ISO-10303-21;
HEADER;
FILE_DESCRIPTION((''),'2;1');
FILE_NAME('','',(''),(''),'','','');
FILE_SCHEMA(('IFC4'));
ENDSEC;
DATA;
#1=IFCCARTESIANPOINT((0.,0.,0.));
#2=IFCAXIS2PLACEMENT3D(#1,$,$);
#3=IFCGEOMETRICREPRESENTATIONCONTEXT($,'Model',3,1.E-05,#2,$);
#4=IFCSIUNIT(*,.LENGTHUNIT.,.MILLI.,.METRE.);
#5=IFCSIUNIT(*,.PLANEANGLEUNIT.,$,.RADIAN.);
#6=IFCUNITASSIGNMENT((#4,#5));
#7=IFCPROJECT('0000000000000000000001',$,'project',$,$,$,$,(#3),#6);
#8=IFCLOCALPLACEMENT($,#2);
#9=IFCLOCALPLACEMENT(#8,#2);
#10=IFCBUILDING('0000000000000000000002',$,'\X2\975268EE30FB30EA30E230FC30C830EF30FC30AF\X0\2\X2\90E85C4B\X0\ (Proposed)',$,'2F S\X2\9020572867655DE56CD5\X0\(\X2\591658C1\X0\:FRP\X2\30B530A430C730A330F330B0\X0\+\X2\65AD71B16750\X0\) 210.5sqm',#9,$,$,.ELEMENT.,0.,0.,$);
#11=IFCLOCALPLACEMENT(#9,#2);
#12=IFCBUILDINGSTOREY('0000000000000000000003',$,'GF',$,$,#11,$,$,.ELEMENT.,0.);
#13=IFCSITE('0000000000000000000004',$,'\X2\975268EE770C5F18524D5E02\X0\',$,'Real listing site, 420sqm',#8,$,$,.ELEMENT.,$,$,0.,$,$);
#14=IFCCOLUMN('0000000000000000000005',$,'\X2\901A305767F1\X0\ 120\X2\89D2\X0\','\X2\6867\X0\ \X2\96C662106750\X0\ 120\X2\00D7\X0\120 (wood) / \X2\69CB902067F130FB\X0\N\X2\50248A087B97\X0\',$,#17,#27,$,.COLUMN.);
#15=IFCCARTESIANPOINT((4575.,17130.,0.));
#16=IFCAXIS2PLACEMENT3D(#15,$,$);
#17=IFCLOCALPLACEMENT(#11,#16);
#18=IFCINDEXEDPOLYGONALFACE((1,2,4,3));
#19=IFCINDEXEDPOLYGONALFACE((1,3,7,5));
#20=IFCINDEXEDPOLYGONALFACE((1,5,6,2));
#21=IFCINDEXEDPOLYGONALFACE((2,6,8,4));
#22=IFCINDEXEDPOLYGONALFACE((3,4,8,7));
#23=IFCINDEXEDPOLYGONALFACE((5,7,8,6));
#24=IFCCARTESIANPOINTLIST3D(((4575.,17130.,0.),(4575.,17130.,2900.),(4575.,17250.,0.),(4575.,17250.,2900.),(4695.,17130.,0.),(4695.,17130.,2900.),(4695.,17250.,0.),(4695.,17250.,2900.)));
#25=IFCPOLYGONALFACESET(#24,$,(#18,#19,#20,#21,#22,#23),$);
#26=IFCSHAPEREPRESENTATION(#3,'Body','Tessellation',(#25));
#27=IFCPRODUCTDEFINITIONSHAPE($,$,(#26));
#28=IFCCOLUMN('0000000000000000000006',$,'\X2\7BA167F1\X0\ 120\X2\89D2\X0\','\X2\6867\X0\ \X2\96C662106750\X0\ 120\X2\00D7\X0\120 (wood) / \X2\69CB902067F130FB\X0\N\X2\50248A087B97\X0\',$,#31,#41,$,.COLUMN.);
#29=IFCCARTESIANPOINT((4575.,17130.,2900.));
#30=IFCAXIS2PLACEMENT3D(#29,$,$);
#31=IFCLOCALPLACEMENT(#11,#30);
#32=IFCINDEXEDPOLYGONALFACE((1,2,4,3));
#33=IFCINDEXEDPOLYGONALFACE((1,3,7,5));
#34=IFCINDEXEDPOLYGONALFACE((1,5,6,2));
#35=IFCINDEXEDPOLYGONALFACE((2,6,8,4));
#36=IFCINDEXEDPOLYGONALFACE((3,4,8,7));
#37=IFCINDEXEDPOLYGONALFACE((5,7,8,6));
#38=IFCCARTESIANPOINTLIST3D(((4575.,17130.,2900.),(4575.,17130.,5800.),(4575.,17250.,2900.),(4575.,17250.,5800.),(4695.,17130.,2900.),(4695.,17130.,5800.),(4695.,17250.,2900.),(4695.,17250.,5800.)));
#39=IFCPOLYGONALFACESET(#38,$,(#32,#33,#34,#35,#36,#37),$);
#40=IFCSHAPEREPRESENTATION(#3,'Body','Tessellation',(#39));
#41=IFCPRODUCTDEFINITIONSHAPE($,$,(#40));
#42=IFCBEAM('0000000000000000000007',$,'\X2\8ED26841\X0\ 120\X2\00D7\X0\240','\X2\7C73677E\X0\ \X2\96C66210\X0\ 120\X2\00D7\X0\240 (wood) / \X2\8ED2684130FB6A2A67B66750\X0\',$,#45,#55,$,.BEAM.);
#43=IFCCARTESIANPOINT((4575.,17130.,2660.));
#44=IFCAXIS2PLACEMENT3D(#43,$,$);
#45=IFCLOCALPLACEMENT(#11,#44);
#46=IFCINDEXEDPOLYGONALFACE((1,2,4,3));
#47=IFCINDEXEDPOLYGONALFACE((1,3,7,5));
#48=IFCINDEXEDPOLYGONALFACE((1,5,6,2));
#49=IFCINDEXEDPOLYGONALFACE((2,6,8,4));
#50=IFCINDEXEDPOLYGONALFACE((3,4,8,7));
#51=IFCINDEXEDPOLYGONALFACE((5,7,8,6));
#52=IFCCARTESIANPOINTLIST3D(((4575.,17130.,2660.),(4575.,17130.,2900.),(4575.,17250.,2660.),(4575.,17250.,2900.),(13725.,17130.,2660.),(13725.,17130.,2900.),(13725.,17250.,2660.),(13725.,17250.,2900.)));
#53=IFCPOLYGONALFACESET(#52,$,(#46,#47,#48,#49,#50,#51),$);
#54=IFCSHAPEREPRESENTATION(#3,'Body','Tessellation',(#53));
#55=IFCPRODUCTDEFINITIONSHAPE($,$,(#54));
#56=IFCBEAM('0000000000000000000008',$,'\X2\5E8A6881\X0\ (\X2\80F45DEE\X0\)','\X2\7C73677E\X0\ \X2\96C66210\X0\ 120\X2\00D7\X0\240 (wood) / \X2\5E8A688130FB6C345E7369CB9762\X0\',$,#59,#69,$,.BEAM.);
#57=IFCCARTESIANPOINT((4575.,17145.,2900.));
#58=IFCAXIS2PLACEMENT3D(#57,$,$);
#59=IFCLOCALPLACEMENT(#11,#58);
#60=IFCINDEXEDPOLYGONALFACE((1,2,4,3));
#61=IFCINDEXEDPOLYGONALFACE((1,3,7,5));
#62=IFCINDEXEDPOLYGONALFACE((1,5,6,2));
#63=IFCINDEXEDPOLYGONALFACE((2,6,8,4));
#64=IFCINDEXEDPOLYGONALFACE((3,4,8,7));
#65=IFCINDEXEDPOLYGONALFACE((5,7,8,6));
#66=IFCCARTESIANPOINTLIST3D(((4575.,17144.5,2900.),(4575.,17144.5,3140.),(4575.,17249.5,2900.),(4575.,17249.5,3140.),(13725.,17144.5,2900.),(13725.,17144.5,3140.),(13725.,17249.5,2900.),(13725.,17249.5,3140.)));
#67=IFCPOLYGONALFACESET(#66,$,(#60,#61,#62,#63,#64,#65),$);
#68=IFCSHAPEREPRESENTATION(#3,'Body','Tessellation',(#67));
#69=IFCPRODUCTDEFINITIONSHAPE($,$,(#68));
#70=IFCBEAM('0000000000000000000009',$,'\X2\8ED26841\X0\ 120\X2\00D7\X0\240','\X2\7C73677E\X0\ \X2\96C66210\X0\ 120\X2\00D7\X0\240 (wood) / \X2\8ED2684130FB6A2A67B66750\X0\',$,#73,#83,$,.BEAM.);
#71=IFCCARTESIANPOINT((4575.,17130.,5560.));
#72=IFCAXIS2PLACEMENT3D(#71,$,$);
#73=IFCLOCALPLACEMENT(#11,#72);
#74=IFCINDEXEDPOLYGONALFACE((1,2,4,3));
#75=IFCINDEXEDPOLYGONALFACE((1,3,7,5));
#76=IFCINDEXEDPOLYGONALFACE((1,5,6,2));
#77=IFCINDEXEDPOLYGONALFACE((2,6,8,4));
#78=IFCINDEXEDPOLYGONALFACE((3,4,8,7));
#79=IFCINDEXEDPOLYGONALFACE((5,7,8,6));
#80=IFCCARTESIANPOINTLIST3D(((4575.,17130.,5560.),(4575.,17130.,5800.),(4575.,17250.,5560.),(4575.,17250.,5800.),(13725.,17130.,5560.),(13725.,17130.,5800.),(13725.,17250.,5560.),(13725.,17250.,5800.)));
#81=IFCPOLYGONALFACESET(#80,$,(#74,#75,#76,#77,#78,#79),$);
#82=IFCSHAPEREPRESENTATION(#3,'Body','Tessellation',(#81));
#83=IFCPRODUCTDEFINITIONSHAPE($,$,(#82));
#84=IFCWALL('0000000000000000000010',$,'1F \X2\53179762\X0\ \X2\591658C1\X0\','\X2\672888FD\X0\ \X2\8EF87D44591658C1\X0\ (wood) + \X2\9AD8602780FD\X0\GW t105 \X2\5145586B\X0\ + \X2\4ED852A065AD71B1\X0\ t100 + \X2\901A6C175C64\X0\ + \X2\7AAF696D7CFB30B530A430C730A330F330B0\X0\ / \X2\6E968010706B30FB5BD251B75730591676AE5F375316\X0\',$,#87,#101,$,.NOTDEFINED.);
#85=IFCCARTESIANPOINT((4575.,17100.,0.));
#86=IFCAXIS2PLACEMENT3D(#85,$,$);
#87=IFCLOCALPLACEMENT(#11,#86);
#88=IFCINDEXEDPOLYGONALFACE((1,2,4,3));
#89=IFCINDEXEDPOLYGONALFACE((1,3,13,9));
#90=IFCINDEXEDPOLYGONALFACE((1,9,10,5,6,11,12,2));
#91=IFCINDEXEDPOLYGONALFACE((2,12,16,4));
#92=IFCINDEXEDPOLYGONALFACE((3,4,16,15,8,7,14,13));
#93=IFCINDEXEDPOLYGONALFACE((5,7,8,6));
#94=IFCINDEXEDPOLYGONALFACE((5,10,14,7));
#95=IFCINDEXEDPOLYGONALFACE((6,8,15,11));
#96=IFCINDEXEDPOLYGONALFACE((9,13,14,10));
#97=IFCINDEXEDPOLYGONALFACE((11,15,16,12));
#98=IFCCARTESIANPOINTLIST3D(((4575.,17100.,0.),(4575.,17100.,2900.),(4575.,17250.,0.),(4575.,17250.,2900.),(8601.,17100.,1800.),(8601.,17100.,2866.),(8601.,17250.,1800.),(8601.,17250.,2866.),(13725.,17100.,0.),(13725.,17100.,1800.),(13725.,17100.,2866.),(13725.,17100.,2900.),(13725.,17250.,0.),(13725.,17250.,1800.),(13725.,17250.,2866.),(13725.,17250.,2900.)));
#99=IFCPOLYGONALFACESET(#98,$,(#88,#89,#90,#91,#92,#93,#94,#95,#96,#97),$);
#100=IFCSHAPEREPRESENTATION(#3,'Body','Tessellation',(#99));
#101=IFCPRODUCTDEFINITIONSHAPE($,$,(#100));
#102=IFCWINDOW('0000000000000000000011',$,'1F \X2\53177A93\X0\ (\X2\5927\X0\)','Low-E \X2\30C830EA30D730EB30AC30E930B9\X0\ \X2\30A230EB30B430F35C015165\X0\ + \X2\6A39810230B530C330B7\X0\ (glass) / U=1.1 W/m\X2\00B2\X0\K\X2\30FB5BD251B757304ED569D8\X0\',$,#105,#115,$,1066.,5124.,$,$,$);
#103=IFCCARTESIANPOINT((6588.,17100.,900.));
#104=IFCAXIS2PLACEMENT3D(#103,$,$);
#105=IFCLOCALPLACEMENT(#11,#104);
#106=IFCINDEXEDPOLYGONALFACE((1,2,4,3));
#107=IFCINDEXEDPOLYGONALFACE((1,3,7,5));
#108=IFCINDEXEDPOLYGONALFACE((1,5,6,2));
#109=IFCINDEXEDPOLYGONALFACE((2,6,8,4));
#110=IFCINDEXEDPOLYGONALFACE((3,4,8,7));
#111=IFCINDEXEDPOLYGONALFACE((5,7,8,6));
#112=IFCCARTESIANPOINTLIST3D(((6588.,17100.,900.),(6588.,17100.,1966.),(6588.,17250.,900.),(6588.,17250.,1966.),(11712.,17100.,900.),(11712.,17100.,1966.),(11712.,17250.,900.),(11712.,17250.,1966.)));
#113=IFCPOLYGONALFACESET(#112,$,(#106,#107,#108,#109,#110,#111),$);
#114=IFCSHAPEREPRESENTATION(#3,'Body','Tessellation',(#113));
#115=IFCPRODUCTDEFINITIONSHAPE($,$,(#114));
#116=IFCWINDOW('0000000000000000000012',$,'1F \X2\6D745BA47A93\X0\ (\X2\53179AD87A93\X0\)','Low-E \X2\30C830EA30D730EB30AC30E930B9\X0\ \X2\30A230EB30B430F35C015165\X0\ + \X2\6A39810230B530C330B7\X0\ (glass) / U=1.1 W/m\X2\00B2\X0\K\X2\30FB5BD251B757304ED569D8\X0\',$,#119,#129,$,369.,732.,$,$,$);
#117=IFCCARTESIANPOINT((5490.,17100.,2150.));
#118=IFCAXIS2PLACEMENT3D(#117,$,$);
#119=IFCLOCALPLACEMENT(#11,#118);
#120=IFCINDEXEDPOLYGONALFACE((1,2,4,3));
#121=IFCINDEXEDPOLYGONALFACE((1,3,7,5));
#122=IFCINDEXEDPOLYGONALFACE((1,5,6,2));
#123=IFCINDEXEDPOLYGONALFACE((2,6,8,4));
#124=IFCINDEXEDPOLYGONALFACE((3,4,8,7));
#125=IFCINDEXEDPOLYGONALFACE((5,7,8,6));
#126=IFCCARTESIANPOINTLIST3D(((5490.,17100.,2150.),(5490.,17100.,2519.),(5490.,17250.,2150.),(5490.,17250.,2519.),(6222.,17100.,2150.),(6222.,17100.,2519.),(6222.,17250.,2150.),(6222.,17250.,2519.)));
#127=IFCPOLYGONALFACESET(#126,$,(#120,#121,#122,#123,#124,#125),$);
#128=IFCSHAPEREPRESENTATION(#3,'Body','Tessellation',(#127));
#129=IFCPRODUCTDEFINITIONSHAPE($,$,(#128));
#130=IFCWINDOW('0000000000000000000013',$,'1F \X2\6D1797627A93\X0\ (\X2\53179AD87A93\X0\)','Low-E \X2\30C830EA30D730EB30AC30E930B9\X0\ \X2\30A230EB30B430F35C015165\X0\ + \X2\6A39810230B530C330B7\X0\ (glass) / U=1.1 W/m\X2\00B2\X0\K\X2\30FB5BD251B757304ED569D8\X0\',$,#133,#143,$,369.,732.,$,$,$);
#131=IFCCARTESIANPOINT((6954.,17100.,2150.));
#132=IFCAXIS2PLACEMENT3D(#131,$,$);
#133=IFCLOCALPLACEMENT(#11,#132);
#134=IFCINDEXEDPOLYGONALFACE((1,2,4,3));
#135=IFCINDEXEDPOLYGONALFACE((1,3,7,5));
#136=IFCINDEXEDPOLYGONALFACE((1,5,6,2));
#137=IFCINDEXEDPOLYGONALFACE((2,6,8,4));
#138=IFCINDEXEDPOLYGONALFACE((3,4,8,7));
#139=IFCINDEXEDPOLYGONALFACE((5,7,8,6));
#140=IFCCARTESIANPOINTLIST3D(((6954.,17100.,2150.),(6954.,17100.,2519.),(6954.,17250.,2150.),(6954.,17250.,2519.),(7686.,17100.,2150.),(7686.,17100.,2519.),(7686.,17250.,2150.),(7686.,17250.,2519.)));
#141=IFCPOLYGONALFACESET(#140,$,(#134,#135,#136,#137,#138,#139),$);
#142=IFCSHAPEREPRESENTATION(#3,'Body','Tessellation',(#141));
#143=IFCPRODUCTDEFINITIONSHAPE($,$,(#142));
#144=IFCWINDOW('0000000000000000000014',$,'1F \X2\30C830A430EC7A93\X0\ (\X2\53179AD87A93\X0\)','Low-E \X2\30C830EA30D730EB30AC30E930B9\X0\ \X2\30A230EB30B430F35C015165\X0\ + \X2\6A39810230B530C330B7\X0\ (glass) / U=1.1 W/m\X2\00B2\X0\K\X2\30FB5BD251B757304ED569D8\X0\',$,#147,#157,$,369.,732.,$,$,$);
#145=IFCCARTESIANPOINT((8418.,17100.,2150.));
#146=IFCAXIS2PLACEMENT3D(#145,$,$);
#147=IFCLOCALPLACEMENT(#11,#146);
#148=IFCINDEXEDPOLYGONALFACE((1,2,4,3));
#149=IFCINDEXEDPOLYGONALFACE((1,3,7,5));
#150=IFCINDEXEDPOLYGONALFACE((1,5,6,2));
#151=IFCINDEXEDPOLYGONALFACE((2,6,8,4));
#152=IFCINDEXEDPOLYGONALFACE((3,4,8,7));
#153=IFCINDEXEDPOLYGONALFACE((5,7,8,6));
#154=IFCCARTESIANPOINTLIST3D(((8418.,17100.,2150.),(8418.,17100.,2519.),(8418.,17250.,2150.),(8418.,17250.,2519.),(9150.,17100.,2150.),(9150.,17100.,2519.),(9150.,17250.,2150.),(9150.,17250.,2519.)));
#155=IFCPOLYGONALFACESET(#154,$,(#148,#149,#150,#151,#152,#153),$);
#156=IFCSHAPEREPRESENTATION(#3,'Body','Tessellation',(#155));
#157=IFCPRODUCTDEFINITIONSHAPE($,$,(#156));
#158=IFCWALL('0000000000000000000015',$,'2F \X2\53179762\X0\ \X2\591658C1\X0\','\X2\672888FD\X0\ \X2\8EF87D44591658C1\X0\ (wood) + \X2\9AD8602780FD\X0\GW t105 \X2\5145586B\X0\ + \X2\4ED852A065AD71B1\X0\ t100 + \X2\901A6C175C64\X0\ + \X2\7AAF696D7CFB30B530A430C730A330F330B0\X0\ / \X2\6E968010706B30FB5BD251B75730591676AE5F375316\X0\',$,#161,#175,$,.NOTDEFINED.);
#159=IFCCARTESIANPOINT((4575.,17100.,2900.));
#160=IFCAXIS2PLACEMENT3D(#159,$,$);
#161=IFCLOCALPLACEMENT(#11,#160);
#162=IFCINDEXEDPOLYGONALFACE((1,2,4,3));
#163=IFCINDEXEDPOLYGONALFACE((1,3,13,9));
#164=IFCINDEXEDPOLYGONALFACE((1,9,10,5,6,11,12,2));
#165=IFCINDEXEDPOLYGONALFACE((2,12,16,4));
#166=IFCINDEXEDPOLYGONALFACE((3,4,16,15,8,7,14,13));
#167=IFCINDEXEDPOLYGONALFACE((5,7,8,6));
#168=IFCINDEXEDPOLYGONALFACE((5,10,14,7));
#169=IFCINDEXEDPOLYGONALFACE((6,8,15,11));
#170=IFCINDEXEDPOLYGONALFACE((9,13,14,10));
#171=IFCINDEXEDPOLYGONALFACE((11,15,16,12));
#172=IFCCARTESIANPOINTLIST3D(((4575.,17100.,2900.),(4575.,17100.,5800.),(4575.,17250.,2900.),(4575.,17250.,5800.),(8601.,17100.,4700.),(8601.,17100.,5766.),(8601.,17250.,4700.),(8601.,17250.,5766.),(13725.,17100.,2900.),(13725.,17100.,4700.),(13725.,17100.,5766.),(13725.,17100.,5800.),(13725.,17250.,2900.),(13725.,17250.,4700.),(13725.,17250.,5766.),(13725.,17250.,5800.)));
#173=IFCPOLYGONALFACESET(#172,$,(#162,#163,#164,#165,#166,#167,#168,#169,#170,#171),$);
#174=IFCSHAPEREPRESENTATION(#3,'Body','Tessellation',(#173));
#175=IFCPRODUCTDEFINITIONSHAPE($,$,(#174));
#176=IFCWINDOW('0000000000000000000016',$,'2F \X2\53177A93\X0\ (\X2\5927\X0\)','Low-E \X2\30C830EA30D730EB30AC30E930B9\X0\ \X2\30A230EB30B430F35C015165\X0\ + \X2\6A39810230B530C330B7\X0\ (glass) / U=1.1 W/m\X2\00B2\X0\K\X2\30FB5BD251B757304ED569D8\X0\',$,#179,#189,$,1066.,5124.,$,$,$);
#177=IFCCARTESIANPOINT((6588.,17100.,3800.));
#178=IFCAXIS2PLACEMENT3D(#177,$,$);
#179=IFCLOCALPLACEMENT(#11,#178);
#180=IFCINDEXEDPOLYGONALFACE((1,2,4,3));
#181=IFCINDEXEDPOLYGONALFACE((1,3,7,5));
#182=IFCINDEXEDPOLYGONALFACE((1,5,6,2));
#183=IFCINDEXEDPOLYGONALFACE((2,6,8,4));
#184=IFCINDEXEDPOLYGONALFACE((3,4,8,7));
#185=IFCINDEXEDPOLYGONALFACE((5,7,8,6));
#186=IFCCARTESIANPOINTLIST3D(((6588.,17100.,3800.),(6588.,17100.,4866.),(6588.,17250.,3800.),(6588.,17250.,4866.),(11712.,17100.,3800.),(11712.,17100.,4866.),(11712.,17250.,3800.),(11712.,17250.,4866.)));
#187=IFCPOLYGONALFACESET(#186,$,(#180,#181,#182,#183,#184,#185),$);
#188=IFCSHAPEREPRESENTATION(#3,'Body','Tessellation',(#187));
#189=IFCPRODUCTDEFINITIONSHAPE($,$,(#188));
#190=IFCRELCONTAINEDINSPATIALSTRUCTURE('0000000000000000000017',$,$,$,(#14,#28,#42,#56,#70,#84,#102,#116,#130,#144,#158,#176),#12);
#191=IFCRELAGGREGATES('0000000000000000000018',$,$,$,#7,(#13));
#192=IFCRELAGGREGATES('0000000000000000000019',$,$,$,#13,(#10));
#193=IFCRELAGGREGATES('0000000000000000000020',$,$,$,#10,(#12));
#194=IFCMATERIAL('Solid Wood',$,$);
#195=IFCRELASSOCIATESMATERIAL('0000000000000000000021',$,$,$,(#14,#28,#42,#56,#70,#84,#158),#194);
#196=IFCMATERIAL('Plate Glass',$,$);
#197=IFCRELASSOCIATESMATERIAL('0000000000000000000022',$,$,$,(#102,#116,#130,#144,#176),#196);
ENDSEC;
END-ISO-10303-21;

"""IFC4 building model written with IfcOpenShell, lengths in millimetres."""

from ifc_helpers import new_model, si_unit, frame, frame_2d, origin, place, context, project, spatial, rectangle, extrude, material, element, fill, save


model = new_model("IFC4")

# Units and contexts
model_context = context("Model", 3, precision=1e-05, world=origin())
ifc_project = project(units=[si_unit("LENGTHUNIT", "METRE", prefix="MILLI"), si_unit("PLANEANGLEUNIT", "RADIAN")], contexts=[model_context])

# Site, building, storey
site_placement = place(None, origin())
site = spatial("IfcSite", under=ifc_project, at=site_placement, Name="青森県弘前市", ObjectType="Real listing site, 420sqm", CompositionType="ELEMENT", RefElevation=0.0)
building_placement = place(site_placement, origin())
building = spatial("IfcBuilding", under=site, at=building_placement, Name="青森・リモートワーク2部屋 (Proposed)", ObjectType="2F S造在来工法(外壁:FRPサイディング+断熱材) 210.5sqm", CompositionType="ELEMENT", ElevationOfRefHeight=0.0, ElevationOfTerrain=0.0)
storey_placement = place(building_placement, origin())
storey = spatial("IfcBuildingStorey", under=building, at=storey_placement, Name="GF", CompositionType="ELEMENT", Elevation=0.0)

# Columns
ifc_material_1 = material(Name="Solid Wood")
column_1_placement = place(storey_placement, frame((4575.0, 17130.0, 0.0)))
element("IfcColumn", 1, at=column_1_placement, inside=storey, material=ifc_material_1, Name="通し柱 120角", Description="桧 集成材 120×120 (wood) / 構造柱・N値計算", PredefinedType="COLUMN", context=model_context, shape_type="SweptSolid", body=[
    extrude(rectangle(XDim=120.0, YDim=120.0, at=frame_2d((60.0, 60.0))), frame((4575.0, 17130.0, 0.0)), (0.0, 0.0, 1.0), 2900.0),
])
column_2_placement = place(storey_placement, frame((4575.0, 17130.0, 2900.0)))
element("IfcColumn", 2, at=column_2_placement, inside=storey, material=ifc_material_1, Name="管柱 120角", Description="桧 集成材 120×120 (wood) / 構造柱・N値計算", PredefinedType="COLUMN", context=model_context, shape_type="SweptSolid", body=[
    extrude(rectangle(XDim=120.0, YDim=120.0, at=frame_2d((60.0, 60.0))), frame((4575.0, 17130.0, 2900.0)), (0.0, 0.0, 1.0), 2900.0),
])

# Beams
beam_1_placement = place(storey_placement, frame((4575.0, 17130.0, 2660.0)))
element("IfcBeam", 3, at=beam_1_placement, inside=storey, material=ifc_material_1, Name="軒桁 120×240", Description="米松 集成 120×240 (wood) / 軒桁・横架材", PredefinedType="BEAM", context=model_context, shape_type="SweptSolid", body=[
    extrude(rectangle(XDim=9150.0, YDim=120.0, at=frame_2d((4575.0, 60.0))), frame((4575.0, 17130.0, 2660.0)), (0.0, 0.0, 1.0), 240.0),
])
beam_2_placement = place(storey_placement, frame((4575.0, 17145.0, 2900.0)))
element("IfcBeam", 4, at=beam_2_placement, inside=storey, material=ifc_material_1, Name="床梁 (胴差)", Description="米松 集成 120×240 (wood) / 床梁・水平構面", PredefinedType="BEAM", context=model_context, shape_type="SweptSolid", body=[
    extrude(rectangle(XDim=9150.0, YDim=105.0, at=frame_2d((4575.0, 52.0))), frame((4575.0, 17145.0, 2900.0)), (0.0, 0.0, 1.0), 240.0),
])
beam_3_placement = place(storey_placement, frame((4575.0, 17130.0, 5560.0)))
element("IfcBeam", 5, at=beam_3_placement, inside=storey, material=ifc_material_1, Name="軒桁 120×240", Description="米松 集成 120×240 (wood) / 軒桁・横架材", PredefinedType="BEAM", context=model_context, shape_type="SweptSolid", body=[
    extrude(rectangle(XDim=9150.0, YDim=120.0, at=frame_2d((4575.0, 60.0))), frame((4575.0, 17130.0, 5560.0)), (0.0, 0.0, 1.0), 240.0),
])

# Wall, openings, windows
wall_1_placement = place(storey_placement, frame((4575.0, 17100.0, 0.0)))
wall_1 = element("IfcWall", 6, at=wall_1_placement, inside=storey, material=ifc_material_1, Name="1F 北面 外壁", Description="木製 軸組外壁 (wood) + 高性能GW t105 充填 + 付加断熱 t100 + 通気層 + 窯業系サイディング / 準耐火・寒冷地外皮強化", PredefinedType="NOTDEFINED", context=model_context, shape_type="SweptSolid", body=[
    extrude(rectangle(XDim=9150.0, YDim=150.0, at=frame_2d((4575.0, 75.0))), frame((4575.0, 17100.0, 0.0)), (0.0, 0.0, 1.0), 2900.0),
])
opening_1_placement = place(storey_placement, frame((6588.0, 17100.0, 900.0)))
opening_1 = element("IfcOpeningElement", 7, at=opening_1_placement, cuts=wall_1, PredefinedType="NOTDEFINED", context=model_context, shape_type="SweptSolid", body=[
    extrude(rectangle(XDim=5124.0, YDim=150.0, at=frame_2d((2562.0, 75.0))), frame((6588.0, 17100.0, 900.0)), (0.0, 0.0, 1.0), 1066.0),
])
opening_2_placement = place(storey_placement, frame((5490.0, 17100.0, 2150.0)))
opening_2 = element("IfcOpeningElement", 8, at=opening_2_placement, cuts=wall_1, PredefinedType="NOTDEFINED", context=model_context, shape_type="SweptSolid", body=[
    extrude(rectangle(XDim=732.0, YDim=150.0, at=frame_2d((366.0, 75.0))), frame((5490.0, 17100.0, 2150.0)), (0.0, 0.0, 1.0), 369.0),
])
opening_3_placement = place(storey_placement, frame((6954.0, 17100.0, 2150.0)))
opening_3 = element("IfcOpeningElement", 9, at=opening_3_placement, cuts=wall_1, PredefinedType="NOTDEFINED", context=model_context, shape_type="SweptSolid", body=[
    extrude(rectangle(XDim=732.0, YDim=150.0, at=frame_2d((366.0, 75.0))), frame((6954.0, 17100.0, 2150.0)), (0.0, 0.0, 1.0), 369.0),
])
opening_4_placement = place(storey_placement, frame((8418.0, 17100.0, 2150.0)))
opening_4 = element("IfcOpeningElement", 10, at=opening_4_placement, cuts=wall_1, PredefinedType="NOTDEFINED", context=model_context, shape_type="SweptSolid", body=[
    extrude(rectangle(XDim=732.0, YDim=150.0, at=frame_2d((366.0, 75.0))), frame((8418.0, 17100.0, 2150.0)), (0.0, 0.0, 1.0), 369.0),
])
ifc_material_2 = material(Name="Plate Glass")
window_1_placement = place(storey_placement, frame((6588.0, 17100.0, 900.0)))
window_1 = element("IfcWindow", 11, at=window_1_placement, inside=storey, material=ifc_material_2, Name="1F 北窓 (大)", Description="Low-E トリプルガラス アルゴン封入 + 樹脂サッシ (glass) / U=1.1 W/m²K・寒冷地仕様", OverallHeight=1066.0, OverallWidth=5124.0, context=model_context, shape_type="SweptSolid", body=[
    extrude(rectangle(XDim=5124.0, YDim=150.0, at=frame_2d((2562.0, 75.0))), frame((6588.0, 17100.0, 900.0)), (0.0, 0.0, 1.0), 1066.0),
])
fill(opening_1, window_1)
window_2_placement = place(storey_placement, frame((5490.0, 17100.0, 2150.0)))
window_2 = element("IfcWindow", 12, at=window_2_placement, inside=storey, material=ifc_material_2, Name="1F 浴室窓 (北高窓)", Description="Low-E トリプルガラス アルゴン封入 + 樹脂サッシ (glass) / U=1.1 W/m²K・寒冷地仕様", OverallHeight=369.0, OverallWidth=732.0, context=model_context, shape_type="SweptSolid", body=[
    extrude(rectangle(XDim=732.0, YDim=150.0, at=frame_2d((366.0, 75.0))), frame((5490.0, 17100.0, 2150.0)), (0.0, 0.0, 1.0), 369.0),
])
fill(opening_2, window_2)
window_3_placement = place(storey_placement, frame((6954.0, 17100.0, 2150.0)))
window_3 = element("IfcWindow", 13, at=window_3_placement, inside=storey, material=ifc_material_2, Name="1F 洗面窓 (北高窓)", Description="Low-E トリプルガラス アルゴン封入 + 樹脂サッシ (glass) / U=1.1 W/m²K・寒冷地仕様", OverallHeight=369.0, OverallWidth=732.0, context=model_context, shape_type="SweptSolid", body=[
    extrude(rectangle(XDim=732.0, YDim=150.0, at=frame_2d((366.0, 75.0))), frame((6954.0, 17100.0, 2150.0)), (0.0, 0.0, 1.0), 369.0),
])
fill(opening_3, window_3)
window_4_placement = place(storey_placement, frame((8418.0, 17100.0, 2150.0)))
window_4 = element("IfcWindow", 14, at=window_4_placement, inside=storey, material=ifc_material_2, Name="1F トイレ窓 (北高窓)", Description="Low-E トリプルガラス アルゴン封入 + 樹脂サッシ (glass) / U=1.1 W/m²K・寒冷地仕様", OverallHeight=369.0, OverallWidth=732.0, context=model_context, shape_type="SweptSolid", body=[
    extrude(rectangle(XDim=732.0, YDim=150.0, at=frame_2d((366.0, 75.0))), frame((8418.0, 17100.0, 2150.0)), (0.0, 0.0, 1.0), 369.0),
])
fill(opening_4, window_4)

# Wall, opening, window
wall_2_placement = place(storey_placement, frame((4575.0, 17100.0, 2900.0)))
wall_2 = element("IfcWall", 15, at=wall_2_placement, inside=storey, material=ifc_material_1, Name="2F 北面 外壁", Description="木製 軸組外壁 (wood) + 高性能GW t105 充填 + 付加断熱 t100 + 通気層 + 窯業系サイディング / 準耐火・寒冷地外皮強化", PredefinedType="NOTDEFINED", context=model_context, shape_type="SweptSolid", body=[
    extrude(rectangle(XDim=9150.0, YDim=150.0, at=frame_2d((4575.0, 75.0))), frame((4575.0, 17100.0, 2900.0)), (0.0, 0.0, 1.0), 2900.0),
])
opening_5_placement = place(storey_placement, frame((6588.0, 17100.0, 3800.0)))
opening_5 = element("IfcOpeningElement", 16, at=opening_5_placement, cuts=wall_2, PredefinedType="NOTDEFINED", context=model_context, shape_type="SweptSolid", body=[
    extrude(rectangle(XDim=5124.0, YDim=150.0, at=frame_2d((2562.0, 75.0))), frame((6588.0, 17100.0, 3800.0)), (0.0, 0.0, 1.0), 1066.0),
])
window_5_placement = place(storey_placement, frame((6588.0, 17100.0, 3800.0)))
window_5 = element("IfcWindow", 17, at=window_5_placement, inside=storey, material=ifc_material_2, Name="2F 北窓 (大)", Description="Low-E トリプルガラス アルゴン封入 + 樹脂サッシ (glass) / U=1.1 W/m²K・寒冷地仕様", OverallHeight=1066.0, OverallWidth=5124.0, context=model_context, shape_type="SweptSolid", body=[
    extrude(rectangle(XDim=5124.0, YDim=150.0, at=frame_2d((2562.0, 75.0))), frame((6588.0, 17100.0, 3800.0)), (0.0, 0.0, 1.0), 1066.0),
])
fill(opening_5, window_5)

save(model, "model.ifc")
